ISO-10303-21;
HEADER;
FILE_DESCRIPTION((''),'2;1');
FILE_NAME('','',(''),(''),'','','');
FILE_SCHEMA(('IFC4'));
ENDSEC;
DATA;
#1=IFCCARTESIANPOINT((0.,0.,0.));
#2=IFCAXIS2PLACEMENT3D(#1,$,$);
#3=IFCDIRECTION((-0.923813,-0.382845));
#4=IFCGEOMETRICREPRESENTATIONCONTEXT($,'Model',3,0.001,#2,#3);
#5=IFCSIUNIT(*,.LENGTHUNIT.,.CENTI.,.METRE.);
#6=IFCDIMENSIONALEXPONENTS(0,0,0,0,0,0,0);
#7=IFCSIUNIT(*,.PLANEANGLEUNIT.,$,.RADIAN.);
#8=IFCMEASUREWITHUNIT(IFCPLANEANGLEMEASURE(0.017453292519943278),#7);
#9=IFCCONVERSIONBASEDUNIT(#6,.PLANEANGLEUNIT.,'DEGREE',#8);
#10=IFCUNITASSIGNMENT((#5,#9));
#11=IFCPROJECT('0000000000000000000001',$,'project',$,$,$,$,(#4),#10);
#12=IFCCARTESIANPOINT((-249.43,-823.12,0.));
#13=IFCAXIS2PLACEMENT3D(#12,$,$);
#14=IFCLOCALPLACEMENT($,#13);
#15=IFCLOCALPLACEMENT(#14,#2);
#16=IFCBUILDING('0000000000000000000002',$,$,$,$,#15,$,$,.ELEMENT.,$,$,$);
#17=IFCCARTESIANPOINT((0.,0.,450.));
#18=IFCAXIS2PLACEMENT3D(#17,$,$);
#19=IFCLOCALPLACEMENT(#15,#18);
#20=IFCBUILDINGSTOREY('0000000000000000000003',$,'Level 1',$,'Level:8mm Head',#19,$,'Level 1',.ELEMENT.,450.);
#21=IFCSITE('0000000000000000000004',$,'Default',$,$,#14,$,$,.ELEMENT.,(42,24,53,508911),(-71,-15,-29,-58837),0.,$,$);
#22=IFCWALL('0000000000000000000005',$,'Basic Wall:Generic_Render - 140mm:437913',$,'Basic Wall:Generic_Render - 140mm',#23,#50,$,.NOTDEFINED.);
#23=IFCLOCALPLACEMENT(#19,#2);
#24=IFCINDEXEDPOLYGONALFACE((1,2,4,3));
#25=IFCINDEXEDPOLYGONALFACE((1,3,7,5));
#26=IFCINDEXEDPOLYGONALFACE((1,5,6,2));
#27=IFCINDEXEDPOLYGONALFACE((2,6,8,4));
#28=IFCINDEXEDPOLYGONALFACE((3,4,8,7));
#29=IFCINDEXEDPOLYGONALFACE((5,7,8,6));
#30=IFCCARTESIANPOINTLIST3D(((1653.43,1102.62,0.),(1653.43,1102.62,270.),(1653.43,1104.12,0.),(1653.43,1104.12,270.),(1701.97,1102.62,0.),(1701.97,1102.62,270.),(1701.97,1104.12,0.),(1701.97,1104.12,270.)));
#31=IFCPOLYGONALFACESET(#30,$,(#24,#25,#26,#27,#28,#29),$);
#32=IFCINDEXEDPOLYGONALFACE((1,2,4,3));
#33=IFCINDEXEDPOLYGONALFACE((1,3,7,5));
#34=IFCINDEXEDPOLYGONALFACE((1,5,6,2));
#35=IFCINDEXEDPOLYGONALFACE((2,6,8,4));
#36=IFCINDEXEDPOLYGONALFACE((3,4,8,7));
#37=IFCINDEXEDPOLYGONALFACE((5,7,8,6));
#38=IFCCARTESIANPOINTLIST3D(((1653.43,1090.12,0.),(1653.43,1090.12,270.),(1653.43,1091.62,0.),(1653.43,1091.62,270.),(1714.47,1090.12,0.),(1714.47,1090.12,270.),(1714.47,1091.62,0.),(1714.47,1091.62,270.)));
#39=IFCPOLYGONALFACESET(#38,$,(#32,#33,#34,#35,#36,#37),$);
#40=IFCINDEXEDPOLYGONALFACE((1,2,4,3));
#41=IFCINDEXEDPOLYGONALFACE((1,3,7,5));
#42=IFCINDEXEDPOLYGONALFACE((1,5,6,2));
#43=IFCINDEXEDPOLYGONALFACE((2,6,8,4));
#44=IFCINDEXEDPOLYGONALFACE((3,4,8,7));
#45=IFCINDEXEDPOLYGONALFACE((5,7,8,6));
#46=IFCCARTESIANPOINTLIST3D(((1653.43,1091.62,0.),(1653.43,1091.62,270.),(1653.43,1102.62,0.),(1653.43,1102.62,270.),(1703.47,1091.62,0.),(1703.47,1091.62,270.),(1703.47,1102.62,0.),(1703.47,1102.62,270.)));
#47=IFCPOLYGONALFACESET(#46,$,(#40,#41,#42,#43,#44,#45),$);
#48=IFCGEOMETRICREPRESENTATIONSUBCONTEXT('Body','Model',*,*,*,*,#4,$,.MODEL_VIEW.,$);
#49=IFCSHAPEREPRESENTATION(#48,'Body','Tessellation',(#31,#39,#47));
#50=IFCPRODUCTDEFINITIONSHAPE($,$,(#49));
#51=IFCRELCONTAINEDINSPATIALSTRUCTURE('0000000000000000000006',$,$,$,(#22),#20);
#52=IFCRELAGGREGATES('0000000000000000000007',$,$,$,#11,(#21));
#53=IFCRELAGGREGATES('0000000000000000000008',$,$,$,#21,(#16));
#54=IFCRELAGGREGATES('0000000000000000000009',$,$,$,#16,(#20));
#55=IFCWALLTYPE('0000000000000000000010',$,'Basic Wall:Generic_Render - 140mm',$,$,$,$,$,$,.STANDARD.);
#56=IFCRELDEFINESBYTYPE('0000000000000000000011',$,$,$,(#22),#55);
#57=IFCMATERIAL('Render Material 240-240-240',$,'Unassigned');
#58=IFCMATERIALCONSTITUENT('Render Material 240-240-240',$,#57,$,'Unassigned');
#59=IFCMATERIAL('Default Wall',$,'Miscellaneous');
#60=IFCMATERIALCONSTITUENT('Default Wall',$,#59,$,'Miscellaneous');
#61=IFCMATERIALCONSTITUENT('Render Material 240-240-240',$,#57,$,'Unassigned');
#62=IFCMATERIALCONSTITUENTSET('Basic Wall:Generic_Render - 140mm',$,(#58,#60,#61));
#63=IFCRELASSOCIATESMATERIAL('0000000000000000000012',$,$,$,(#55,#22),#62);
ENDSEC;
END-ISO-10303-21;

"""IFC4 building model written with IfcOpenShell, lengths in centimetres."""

from ifc_helpers import new_model, entity, si_unit, converted_unit, direction, frame, origin, place, context, subcontext, project, spatial, indexed_curve, outline, extrude, material, constituent, constituent_set, type_object, element, save


model = new_model("IFC4")

# Units and contexts
model_context = context("Model", 3, precision=0.001, world=origin(), true_north=direction((-0.923813, -0.382845)))
body_context = subcontext(model_context, "Body", "Model", "MODEL_VIEW")
ifc_project = project(units=[si_unit("LENGTHUNIT", "METRE", prefix="CENTI"), converted_unit("PLANEANGLEUNIT", "DEGREE", entity("IfcPlaneAngleMeasure", 0.017453292519943278), si_unit("PLANEANGLEUNIT", "RADIAN"), dimensions=[0, 0, 0, 0, 0, 0, 0])], contexts=[model_context])

# Site, building, storey
site_placement = place(None, frame((-249.43, -823.12, 0.0)))
site = spatial("IfcSite", under=ifc_project, at=site_placement, Name="Default", CompositionType="ELEMENT", RefLatitude=(42, 24, 53, 508911), RefLongitude=(-71, -15, -29, -58837), RefElevation=0.0)
building_placement = place(site_placement, origin())
building = spatial("IfcBuilding", under=site, at=building_placement, CompositionType="ELEMENT")
storey_placement = place(building_placement, frame((0.0, 0.0, 450.0)))
storey = spatial("IfcBuildingStorey", under=building, at=storey_placement, Name="Level 1", ObjectType="Level:8mm Head", LongName="Level 1", CompositionType="ELEMENT", Elevation=450.0)

# Wall
ifc_material_1 = material(Name="Render Material 240-240-240", Category="Unassigned")
ifc_material_2 = material(Name="Default Wall", Category="Miscellaneous")
ifc_constituent_1 = constituent(ifc_material_1, Name="Render Material 240-240-240", Category="Unassigned")
ifc_constituent_2 = constituent(ifc_material_2, Name="Default Wall", Category="Miscellaneous")
ifc_constituent_3 = constituent(ifc_material_1, Name="Render Material 240-240-240", Category="Unassigned")
ifc_constituent_set_1 = constituent_set(constituents=[ifc_constituent_1, ifc_constituent_2, ifc_constituent_3], Name="Basic Wall:Generic_Render - 140mm")
wall_type_1 = type_object("IfcWallType", Name="Basic Wall:Generic_Render - 140mm", PredefinedType="STANDARD", material=ifc_constituent_set_1)
wall_1_placement = place(storey_placement, frame((1701.97, 1097.12, 0.0), z_axis=(0.0, 0.0, 1.0), x_axis=(-1.0, 0.0, 0.0)))
element("IfcWall", 1, at=wall_1_placement, inside=storey, type_object=wall_type_1, material=ifc_constituent_set_1, Name="Basic Wall:Generic_Render - 140mm:437913", ObjectType="Basic Wall:Generic_Render - 140mm", PredefinedType="NOTDEFINED", context=body_context, shape_type="SweptSolid", body=[
    extrude(outline(indexed_curve([(-0.75, -24.27), (0.75, -24.27), (0.75, 24.27), (-0.75, 24.27), (-0.75, -24.27)], self_intersect=False)), frame((24.27, -6.25, 0.0), z_axis=(0.0, 0.0, 1.0), x_axis=(0.0, 1.0, 0.0)), (0.0, 0.0, 1.0), 270.0),
    extrude(outline(indexed_curve([(-0.75, -30.52), (0.75, -30.52), (0.75, 30.52), (-0.75, 30.52), (-0.75, -30.52)], self_intersect=False)), frame((18.02, 6.25, 0.0), z_axis=(0.0, 0.0, 1.0), x_axis=(0.0, -1.0, 0.0)), (0.0, 0.0, 1.0), 270.0),
    extrude(outline(indexed_curve([(-25.02, -5.5), (25.02, -5.5), (25.02, 5.5), (-25.02, 5.5), (-25.02, -5.5)], self_intersect=False)), frame((23.52, 0.0, 0.0)), (0.0, 0.0, 1.0), 270.0),
])

save(model, "model.ifc")
